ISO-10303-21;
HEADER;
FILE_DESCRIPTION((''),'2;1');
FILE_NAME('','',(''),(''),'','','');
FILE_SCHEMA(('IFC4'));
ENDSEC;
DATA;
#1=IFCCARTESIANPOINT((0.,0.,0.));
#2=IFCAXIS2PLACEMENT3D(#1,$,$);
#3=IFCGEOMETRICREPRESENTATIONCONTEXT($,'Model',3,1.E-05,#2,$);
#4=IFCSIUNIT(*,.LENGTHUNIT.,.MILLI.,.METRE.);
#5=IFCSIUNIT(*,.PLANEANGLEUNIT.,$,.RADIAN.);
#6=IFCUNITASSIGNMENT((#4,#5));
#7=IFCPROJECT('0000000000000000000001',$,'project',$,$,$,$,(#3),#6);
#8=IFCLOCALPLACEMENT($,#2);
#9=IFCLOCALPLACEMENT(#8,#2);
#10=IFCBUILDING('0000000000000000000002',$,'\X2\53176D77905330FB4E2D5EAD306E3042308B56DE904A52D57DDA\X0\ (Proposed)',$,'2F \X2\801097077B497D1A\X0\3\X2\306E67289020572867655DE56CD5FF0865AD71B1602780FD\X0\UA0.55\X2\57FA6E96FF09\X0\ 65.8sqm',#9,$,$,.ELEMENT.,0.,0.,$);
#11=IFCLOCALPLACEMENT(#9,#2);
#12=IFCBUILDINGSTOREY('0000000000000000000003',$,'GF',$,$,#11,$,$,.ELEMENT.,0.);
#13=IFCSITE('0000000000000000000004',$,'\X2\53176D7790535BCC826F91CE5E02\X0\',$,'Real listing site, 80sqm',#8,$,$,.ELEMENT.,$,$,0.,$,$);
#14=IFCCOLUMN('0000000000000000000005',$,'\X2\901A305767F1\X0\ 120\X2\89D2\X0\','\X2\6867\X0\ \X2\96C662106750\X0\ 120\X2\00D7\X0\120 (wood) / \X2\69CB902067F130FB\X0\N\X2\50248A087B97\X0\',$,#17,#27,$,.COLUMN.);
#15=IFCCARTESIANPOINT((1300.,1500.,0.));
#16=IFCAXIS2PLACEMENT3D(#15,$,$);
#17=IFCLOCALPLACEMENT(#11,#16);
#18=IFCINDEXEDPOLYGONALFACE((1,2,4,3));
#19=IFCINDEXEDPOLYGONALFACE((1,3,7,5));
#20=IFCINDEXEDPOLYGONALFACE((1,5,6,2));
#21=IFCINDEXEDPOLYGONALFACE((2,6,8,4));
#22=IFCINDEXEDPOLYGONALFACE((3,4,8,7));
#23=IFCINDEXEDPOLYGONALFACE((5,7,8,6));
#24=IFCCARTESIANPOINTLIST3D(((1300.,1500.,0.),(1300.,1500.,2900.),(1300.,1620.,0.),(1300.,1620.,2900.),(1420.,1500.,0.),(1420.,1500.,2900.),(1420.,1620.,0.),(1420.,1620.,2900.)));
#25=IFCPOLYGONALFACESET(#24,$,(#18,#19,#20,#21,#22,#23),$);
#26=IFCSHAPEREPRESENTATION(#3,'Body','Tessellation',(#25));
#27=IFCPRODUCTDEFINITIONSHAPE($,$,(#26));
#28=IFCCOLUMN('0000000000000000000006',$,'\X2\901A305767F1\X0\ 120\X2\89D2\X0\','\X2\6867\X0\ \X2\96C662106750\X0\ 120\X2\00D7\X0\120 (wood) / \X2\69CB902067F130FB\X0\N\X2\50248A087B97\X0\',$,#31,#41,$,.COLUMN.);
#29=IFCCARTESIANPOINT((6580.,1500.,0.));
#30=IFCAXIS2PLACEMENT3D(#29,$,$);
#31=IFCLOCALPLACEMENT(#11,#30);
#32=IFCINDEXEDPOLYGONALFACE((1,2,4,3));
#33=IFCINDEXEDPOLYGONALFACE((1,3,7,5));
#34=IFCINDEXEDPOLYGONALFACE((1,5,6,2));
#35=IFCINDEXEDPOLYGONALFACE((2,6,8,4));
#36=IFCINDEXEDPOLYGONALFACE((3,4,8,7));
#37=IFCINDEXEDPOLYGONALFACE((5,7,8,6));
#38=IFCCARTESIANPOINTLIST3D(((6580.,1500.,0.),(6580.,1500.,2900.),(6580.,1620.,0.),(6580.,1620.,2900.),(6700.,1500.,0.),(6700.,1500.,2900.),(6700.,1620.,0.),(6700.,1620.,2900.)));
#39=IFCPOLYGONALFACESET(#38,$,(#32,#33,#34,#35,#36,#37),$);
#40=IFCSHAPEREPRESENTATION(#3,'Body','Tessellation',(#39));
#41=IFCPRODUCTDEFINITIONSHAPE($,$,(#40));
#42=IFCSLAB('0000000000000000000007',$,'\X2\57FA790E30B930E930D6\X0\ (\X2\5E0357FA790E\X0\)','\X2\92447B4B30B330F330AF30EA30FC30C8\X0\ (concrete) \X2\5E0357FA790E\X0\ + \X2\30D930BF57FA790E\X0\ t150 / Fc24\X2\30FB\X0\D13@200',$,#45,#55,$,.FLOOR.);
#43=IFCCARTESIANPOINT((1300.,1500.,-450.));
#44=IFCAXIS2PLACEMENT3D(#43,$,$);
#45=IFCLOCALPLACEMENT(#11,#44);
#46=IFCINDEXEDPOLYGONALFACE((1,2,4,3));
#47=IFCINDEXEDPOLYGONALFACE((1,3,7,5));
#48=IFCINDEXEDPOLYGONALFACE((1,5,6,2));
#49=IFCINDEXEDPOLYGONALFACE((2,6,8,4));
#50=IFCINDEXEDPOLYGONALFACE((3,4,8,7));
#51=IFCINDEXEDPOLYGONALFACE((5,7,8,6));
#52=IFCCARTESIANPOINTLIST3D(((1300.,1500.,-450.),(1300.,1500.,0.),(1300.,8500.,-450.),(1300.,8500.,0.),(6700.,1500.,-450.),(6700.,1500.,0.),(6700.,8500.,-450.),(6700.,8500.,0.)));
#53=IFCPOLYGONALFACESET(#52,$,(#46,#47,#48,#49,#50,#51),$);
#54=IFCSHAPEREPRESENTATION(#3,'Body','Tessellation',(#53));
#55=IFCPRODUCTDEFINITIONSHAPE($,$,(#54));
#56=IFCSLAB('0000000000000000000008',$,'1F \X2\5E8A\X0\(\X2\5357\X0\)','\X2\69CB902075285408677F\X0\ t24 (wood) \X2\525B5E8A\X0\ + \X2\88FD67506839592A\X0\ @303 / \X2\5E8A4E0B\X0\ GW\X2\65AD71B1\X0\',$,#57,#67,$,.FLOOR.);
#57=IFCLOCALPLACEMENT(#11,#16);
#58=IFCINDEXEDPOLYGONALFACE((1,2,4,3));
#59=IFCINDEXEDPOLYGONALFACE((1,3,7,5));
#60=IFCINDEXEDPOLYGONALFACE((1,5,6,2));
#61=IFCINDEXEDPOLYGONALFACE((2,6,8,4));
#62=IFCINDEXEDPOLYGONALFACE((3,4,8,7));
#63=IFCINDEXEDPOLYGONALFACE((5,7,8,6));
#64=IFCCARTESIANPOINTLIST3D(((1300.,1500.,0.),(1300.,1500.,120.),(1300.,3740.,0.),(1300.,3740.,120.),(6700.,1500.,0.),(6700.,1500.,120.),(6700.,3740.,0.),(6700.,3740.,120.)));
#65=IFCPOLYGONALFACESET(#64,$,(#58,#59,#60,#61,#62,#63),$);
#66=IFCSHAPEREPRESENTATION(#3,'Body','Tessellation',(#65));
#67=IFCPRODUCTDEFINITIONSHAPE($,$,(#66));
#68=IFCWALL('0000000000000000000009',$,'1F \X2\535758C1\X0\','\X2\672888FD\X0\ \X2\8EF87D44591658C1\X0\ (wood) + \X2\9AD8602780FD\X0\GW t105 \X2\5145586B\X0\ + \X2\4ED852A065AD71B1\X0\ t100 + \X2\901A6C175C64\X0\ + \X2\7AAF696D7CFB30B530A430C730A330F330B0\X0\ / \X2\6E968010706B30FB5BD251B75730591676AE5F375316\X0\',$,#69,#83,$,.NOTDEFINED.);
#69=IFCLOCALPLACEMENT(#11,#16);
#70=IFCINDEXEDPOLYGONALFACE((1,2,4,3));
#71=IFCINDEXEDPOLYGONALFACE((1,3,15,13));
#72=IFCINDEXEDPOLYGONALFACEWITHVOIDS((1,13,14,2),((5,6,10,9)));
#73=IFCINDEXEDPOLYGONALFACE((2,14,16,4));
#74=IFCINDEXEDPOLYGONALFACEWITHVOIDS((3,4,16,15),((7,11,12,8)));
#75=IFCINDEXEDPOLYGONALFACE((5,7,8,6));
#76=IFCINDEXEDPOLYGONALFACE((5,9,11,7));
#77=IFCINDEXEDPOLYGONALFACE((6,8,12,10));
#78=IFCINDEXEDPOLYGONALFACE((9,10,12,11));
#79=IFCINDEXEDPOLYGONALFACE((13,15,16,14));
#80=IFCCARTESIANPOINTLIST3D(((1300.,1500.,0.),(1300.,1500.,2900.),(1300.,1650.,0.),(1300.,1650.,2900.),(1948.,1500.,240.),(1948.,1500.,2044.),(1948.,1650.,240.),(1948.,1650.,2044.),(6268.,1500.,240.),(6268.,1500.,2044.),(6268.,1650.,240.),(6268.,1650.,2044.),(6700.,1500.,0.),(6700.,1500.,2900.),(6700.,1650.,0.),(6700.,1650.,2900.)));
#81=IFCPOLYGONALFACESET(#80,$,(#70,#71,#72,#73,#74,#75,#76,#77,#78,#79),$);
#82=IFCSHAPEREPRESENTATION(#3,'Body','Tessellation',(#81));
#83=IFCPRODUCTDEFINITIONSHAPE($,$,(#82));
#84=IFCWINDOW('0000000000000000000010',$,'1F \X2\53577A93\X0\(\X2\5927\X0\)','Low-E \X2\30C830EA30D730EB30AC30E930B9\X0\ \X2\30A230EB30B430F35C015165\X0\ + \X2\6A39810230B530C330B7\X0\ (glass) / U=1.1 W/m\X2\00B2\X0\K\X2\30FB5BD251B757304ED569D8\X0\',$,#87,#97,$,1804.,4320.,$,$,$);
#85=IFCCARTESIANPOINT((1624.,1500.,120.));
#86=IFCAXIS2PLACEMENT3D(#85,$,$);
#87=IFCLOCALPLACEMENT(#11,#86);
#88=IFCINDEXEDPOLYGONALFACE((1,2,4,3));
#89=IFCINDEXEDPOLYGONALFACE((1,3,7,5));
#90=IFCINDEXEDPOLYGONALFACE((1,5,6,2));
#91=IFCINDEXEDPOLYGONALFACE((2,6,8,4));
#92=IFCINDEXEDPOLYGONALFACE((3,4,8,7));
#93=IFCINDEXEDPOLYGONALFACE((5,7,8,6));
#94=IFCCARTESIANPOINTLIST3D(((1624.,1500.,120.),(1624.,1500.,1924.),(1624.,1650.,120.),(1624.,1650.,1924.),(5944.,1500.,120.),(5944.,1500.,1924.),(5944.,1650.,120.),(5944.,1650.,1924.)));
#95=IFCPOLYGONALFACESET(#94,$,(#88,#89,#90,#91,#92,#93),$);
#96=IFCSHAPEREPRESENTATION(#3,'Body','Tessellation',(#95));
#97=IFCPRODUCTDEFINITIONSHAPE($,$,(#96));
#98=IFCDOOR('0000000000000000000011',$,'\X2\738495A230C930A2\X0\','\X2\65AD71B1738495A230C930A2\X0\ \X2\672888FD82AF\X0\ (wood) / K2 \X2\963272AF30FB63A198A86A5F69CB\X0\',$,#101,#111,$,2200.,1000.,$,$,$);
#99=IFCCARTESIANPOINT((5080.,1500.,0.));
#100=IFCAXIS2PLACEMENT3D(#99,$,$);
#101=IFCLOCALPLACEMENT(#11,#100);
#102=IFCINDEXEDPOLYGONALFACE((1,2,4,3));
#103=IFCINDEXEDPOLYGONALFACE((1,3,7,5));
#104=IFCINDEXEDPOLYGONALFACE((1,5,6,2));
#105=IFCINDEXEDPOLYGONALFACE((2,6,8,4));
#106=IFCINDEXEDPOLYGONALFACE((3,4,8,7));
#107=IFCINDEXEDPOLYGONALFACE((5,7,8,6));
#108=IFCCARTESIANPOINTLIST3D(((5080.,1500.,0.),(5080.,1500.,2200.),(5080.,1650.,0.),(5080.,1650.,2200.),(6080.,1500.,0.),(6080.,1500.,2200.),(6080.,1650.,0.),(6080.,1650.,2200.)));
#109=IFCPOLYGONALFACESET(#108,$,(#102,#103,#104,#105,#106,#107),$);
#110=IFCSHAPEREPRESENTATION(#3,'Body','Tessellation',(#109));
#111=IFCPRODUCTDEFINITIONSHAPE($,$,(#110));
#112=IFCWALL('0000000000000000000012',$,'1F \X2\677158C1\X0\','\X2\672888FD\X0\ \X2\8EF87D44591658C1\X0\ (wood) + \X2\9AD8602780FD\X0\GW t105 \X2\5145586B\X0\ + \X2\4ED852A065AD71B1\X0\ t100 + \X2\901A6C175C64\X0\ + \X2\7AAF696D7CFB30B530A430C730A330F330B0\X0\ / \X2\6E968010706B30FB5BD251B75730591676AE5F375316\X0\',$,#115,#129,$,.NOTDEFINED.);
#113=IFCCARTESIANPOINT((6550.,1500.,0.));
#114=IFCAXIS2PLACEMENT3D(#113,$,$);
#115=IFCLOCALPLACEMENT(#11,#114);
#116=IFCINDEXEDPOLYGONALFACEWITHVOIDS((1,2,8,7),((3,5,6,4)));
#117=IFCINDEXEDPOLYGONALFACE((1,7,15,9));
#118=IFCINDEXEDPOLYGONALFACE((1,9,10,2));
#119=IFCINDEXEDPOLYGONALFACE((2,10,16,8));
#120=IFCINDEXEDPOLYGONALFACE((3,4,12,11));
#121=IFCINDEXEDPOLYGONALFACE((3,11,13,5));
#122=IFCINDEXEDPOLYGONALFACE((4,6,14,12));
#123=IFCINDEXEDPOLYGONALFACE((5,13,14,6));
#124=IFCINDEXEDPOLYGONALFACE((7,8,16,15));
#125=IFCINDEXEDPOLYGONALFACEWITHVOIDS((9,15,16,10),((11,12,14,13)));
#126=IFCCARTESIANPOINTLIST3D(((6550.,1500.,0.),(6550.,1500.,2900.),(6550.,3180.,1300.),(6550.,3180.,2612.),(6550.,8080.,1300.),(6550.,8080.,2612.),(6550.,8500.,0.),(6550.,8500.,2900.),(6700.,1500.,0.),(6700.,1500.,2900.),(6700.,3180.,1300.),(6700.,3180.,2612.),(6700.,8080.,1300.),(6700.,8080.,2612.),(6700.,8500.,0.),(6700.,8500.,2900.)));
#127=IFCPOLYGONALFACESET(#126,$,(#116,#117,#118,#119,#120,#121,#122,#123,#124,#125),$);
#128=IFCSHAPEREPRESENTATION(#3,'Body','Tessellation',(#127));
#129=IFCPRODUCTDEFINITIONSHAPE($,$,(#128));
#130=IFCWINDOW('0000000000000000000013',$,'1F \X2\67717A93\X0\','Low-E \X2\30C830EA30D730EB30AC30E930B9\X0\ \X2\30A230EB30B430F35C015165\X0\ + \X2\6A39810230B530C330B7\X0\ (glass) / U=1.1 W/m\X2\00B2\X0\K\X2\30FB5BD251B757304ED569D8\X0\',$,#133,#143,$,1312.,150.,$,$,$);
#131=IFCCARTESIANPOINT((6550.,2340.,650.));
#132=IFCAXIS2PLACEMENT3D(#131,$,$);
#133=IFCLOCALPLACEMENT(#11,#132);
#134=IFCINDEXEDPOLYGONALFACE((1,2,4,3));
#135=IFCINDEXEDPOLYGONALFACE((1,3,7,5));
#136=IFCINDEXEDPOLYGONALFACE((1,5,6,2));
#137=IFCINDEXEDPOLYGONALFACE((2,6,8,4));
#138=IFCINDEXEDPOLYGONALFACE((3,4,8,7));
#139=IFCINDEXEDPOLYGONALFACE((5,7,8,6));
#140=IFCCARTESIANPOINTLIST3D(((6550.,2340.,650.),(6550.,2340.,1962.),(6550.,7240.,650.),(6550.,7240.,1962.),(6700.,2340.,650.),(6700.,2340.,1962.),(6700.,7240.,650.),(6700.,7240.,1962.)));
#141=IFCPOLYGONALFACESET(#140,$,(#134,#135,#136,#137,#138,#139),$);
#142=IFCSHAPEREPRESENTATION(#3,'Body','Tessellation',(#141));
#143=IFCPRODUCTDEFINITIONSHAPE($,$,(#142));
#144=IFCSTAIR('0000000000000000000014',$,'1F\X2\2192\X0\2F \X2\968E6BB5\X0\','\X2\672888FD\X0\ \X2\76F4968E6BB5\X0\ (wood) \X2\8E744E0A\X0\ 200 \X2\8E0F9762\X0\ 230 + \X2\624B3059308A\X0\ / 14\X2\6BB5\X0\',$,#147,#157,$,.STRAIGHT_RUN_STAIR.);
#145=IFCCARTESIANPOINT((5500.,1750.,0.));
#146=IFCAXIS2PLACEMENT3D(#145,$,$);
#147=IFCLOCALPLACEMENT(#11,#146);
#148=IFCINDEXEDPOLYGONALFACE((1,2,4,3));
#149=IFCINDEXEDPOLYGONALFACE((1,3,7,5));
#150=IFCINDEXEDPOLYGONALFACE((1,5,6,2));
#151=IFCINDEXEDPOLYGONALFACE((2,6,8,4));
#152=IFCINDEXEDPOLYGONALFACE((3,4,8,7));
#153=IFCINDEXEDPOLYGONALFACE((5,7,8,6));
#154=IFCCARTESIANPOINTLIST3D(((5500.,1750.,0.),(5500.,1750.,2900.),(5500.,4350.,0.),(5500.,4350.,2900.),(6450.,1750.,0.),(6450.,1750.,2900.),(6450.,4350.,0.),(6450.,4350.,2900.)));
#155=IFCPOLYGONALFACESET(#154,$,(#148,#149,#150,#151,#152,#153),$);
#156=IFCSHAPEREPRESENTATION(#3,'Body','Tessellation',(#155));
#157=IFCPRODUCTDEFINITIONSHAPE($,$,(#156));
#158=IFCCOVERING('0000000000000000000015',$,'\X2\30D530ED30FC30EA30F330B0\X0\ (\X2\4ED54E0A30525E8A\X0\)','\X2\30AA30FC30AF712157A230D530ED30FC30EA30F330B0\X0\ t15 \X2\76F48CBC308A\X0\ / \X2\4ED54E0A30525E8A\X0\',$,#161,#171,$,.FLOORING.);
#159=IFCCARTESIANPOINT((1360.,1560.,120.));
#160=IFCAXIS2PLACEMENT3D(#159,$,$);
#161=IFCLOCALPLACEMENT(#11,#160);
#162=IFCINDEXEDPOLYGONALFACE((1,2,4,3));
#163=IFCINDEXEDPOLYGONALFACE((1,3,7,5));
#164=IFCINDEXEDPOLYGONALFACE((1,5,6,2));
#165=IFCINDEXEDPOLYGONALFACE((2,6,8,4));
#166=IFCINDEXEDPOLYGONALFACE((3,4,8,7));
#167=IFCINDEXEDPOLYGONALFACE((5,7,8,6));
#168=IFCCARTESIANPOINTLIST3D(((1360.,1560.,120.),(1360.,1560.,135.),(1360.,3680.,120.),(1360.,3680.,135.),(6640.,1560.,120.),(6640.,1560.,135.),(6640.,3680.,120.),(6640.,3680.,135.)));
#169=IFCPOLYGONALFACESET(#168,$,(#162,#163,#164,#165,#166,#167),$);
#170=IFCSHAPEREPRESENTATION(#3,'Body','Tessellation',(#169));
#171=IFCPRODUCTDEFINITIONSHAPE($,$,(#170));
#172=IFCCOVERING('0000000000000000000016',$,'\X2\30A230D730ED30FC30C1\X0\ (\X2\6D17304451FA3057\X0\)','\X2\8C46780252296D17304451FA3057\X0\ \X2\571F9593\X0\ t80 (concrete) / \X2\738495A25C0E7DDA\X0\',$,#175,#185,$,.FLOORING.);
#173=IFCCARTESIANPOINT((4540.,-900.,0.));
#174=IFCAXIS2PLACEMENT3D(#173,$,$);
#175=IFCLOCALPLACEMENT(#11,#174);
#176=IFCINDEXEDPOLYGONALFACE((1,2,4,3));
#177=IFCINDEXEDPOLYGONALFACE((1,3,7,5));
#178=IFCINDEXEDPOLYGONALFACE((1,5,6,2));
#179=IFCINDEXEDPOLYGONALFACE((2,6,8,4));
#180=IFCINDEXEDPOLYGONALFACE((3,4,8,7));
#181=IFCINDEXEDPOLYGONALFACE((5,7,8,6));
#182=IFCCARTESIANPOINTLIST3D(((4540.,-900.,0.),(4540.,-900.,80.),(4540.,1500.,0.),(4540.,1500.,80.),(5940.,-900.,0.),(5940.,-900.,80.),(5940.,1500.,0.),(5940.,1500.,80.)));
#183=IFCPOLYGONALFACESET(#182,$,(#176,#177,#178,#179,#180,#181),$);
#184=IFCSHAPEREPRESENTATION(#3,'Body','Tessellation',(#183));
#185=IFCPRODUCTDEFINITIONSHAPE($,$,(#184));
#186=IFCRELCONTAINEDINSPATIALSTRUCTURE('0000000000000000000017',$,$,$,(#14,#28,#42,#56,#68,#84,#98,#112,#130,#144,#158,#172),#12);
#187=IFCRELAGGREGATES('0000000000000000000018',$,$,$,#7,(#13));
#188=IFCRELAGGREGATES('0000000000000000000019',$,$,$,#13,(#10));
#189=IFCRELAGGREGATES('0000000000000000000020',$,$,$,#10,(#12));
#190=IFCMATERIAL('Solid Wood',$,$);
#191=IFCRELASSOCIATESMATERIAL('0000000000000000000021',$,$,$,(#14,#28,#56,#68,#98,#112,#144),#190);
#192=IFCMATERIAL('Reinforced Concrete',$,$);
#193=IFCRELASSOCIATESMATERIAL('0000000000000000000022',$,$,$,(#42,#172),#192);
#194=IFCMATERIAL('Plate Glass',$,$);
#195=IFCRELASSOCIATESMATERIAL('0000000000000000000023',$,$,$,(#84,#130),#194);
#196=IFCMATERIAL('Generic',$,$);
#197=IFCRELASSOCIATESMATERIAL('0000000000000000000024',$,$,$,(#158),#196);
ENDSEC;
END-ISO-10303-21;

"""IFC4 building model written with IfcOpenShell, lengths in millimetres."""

from ifc_helpers import new_model, si_unit, frame, frame_2d, origin, place, context, project, spatial, rectangle, extrude, material, element, fill, save


model = new_model("IFC4")

# Units and contexts
model_context = context("Model", 3, precision=1e-05, world=origin())
ifc_project = project(units=[si_unit("LENGTHUNIT", "METRE", prefix="MILLI"), si_unit("PLANEANGLEUNIT", "RADIAN")], contexts=[model_context])

# Site, building, storey
site_placement = place(None, origin())
site = spatial("IfcSite", under=ifc_project, at=site_placement, Name="北海道富良野市", ObjectType="Real listing site, 80sqm", CompositionType="ELEMENT", RefElevation=0.0)
building_placement = place(site_placement, origin())
building = spatial("IfcBuilding", under=site, at=building_placement, Name="北海道・中庭のある回遊動線 (Proposed)", ObjectType="2F 耐震等級3の木造在来工法（断熱性能UA0.55基準） 65.8sqm", CompositionType="ELEMENT", ElevationOfRefHeight=0.0, ElevationOfTerrain=0.0)
storey_placement = place(building_placement, origin())
storey = spatial("IfcBuildingStorey", under=building, at=storey_placement, Name="GF", CompositionType="ELEMENT", Elevation=0.0)

# Columns
ifc_material_1 = material(Name="Solid Wood")
column_1_placement = place(storey_placement, frame((1300.0, 1500.0, 0.0)))
element("IfcColumn", 1, at=column_1_placement, inside=storey, material=ifc_material_1, Name="通し柱 120角", Description="桧 集成材 120×120 (wood) / 構造柱・N値計算", PredefinedType="COLUMN", context=model_context, shape_type="SweptSolid", body=[
    extrude(rectangle(XDim=120.0, YDim=120.0, at=frame_2d((60.0, 60.0))), frame((1300.0, 1500.0, 0.0)), (0.0, 0.0, 1.0), 2900.0),
])
column_2_placement = place(storey_placement, frame((6580.0, 1500.0, 0.0)))
element("IfcColumn", 2, at=column_2_placement, inside=storey, material=ifc_material_1, Name="通し柱 120角", Description="桧 集成材 120×120 (wood) / 構造柱・N値計算", PredefinedType="COLUMN", context=model_context, shape_type="SweptSolid", body=[
    extrude(rectangle(XDim=120.0, YDim=120.0, at=frame_2d((60.0, 60.0))), frame((6580.0, 1500.0, 0.0)), (0.0, 0.0, 1.0), 2900.0),
])

# Slabs
ifc_material_2 = material(Name="Reinforced Concrete")
slab_1_placement = place(storey_placement, frame((1300.0, 1500.0, -450.0)))
element("IfcSlab", 3, at=slab_1_placement, inside=storey, material=ifc_material_2, Name="基礎スラブ (布基礎)", Description="鉄筋コンクリート (concrete) 布基礎 + ベタ基礎 t150 / Fc24・D13@200", PredefinedType="FLOOR", context=model_context, shape_type="SweptSolid", body=[
    extrude(rectangle(XDim=5400.0, YDim=7000.0, at=frame_2d((2700.0, 3500.0))), frame((1300.0, 1500.0, -450.0)), (0.0, 0.0, 1.0), 450.0),
])
slab_2_placement = place(storey_placement, frame((1300.0, 1500.0, 0.0)))
element("IfcSlab", 4, at=slab_2_placement, inside=storey, material=ifc_material_1, Name="1F 床(南)", Description="構造用合板 t24 (wood) 剛床 + 製材根太 @303 / 床下 GW断熱", PredefinedType="FLOOR", context=model_context, shape_type="SweptSolid", body=[
    extrude(rectangle(XDim=5400.0, YDim=2240.0, at=frame_2d((2700.0, 1120.0))), frame((1300.0, 1500.0, 0.0)), (0.0, 0.0, 1.0), 120.0),
])

# Wall, openings, window, door
wall_1_placement = place(storey_placement, frame((1300.0, 1500.0, 0.0)))
wall_1 = element("IfcWall", 5, at=wall_1_placement, inside=storey, material=ifc_material_1, Name="1F 南壁", Description="木製 軸組外壁 (wood) + 高性能GW t105 充填 + 付加断熱 t100 + 通気層 + 窯業系サイディング / 準耐火・寒冷地外皮強化", PredefinedType="NOTDEFINED", context=model_context, shape_type="SweptSolid", body=[
    extrude(rectangle(XDim=5400.0, YDim=150.0, at=frame_2d((2700.0, 75.0))), frame((1300.0, 1500.0, 0.0)), (0.0, 0.0, 1.0), 2900.0),
])
opening_1_placement = place(storey_placement, frame((1624.0, 1500.0, 120.0)))
opening_1 = element("IfcOpeningElement", 6, at=opening_1_placement, cuts=wall_1, PredefinedType="NOTDEFINED", context=model_context, shape_type="SweptSolid", body=[
    extrude(rectangle(XDim=4320.0, YDim=150.0, at=frame_2d((2160.0, 75.0))), frame((1624.0, 1500.0, 120.0)), (0.0, 0.0, 1.0), 1804.0),
])
opening_2_placement = place(storey_placement, frame((5080.0, 1500.0, 0.0)))
opening_2 = element("IfcOpeningElement", 7, at=opening_2_placement, cuts=wall_1, PredefinedType="NOTDEFINED", context=model_context, shape_type="SweptSolid", body=[
    extrude(rectangle(XDim=1000.0, YDim=150.0, at=frame_2d((500.0, 75.0))), frame((5080.0, 1500.0, 0.0)), (0.0, 0.0, 1.0), 2200.0),
])
ifc_material_3 = material(Name="Plate Glass")
window_1_placement = place(storey_placement, frame((1624.0, 1500.0, 120.0)))
window_1 = element("IfcWindow", 8, at=window_1_placement, inside=storey, material=ifc_material_3, Name="1F 南窓(大)", Description="Low-E トリプルガラス アルゴン封入 + 樹脂サッシ (glass) / U=1.1 W/m²K・寒冷地仕様", OverallHeight=1804.0, OverallWidth=4320.0, context=model_context, shape_type="SweptSolid", body=[
    extrude(rectangle(XDim=4320.0, YDim=150.0, at=frame_2d((2160.0, 75.0))), frame((1624.0, 1500.0, 120.0)), (0.0, 0.0, 1.0), 1804.0),
])
fill(opening_1, window_1)
door_placement = place(storey_placement, frame((5080.0, 1500.0, 0.0)))
door = element("IfcDoor", 9, at=door_placement, inside=storey, material=ifc_material_1, Name="玄関ドア", Description="断熱玄関ドア 木製芯 (wood) / K2 防犯・採風機構", OverallHeight=2200.0, OverallWidth=1000.0, context=model_context, shape_type="SweptSolid", body=[
    extrude(rectangle(XDim=1000.0, YDim=150.0, at=frame_2d((500.0, 75.0))), frame((5080.0, 1500.0, 0.0)), (0.0, 0.0, 1.0), 2200.0),
])
fill(opening_2, door)

# Wall, opening, window
wall_2_placement = place(storey_placement, frame((6550.0, 1500.0, 0.0)))
wall_2 = element("IfcWall", 10, at=wall_2_placement, inside=storey, material=ifc_material_1, Name="1F 東壁", Description="木製 軸組外壁 (wood) + 高性能GW t105 充填 + 付加断熱 t100 + 通気層 + 窯業系サイディング / 準耐火・寒冷地外皮強化", PredefinedType="NOTDEFINED", context=model_context, shape_type="SweptSolid", body=[
    extrude(rectangle(XDim=150.0, YDim=7000.0, at=frame_2d((75.0, 3500.0))), frame((6550.0, 1500.0, 0.0)), (0.0, 0.0, 1.0), 2900.0),
])
opening_3_placement = place(storey_placement, frame((6550.0, 2340.0, 650.0)))
opening_3 = element("IfcOpeningElement", 11, at=opening_3_placement, cuts=wall_2, PredefinedType="NOTDEFINED", context=model_context, shape_type="SweptSolid", body=[
    extrude(rectangle(XDim=150.0, YDim=4900.0, at=frame_2d((75.0, 2450.0))), frame((6550.0, 2340.0, 650.0)), (0.0, 0.0, 1.0), 1312.0),
])
window_2_placement = place(storey_placement, frame((6550.0, 2340.0, 650.0)))
window_2 = element("IfcWindow", 12, at=window_2_placement, inside=storey, material=ifc_material_3, Name="1F 東窓", Description="Low-E トリプルガラス アルゴン封入 + 樹脂サッシ (glass) / U=1.1 W/m²K・寒冷地仕様", OverallHeight=1312.0, OverallWidth=150.0, context=model_context, shape_type="SweptSolid", body=[
    extrude(rectangle(XDim=150.0, YDim=4900.0, at=frame_2d((75.0, 2450.0))), frame((6550.0, 2340.0, 650.0)), (0.0, 0.0, 1.0), 1312.0),
])
fill(opening_3, window_2)

# Stair
stair_placement = place(storey_placement, frame((5500.0, 1750.0, 0.0)))
element("IfcStair", 13, at=stair_placement, inside=storey, material=ifc_material_1, Name="1F→2F 階段", Description="木製 直階段 (wood) 蹴上 200 踏面 230 + 手すり / 14段", PredefinedType="STRAIGHT_RUN_STAIR", context=model_context, shape_type="SweptSolid", body=[
    extrude(rectangle(XDim=950.0, YDim=2600.0, at=frame_2d((475.0, 1300.0))), frame((5500.0, 1750.0, 0.0)), (0.0, 0.0, 1.0), 2900.0),
])

# Coverings
ifc_material_4 = material(Name="Generic")
covering_1_placement = place(storey_placement, frame((1360.0, 1560.0, 120.0)))
element("IfcCovering", 14, at=covering_1_placement, inside=storey, material=ifc_material_4, Name="フローリング (仕上げ床)", Description="オーク無垢フローリング t15 直貼り / 仕上げ床", PredefinedType="FLOORING", context=model_context, shape_type="SweptSolid", body=[
    extrude(rectangle(XDim=5280.0, YDim=2120.0, at=frame_2d((2640.0, 1060.0))), frame((1360.0, 1560.0, 120.0)), (0.0, 0.0, 1.0), 15.0),
])
covering_2_placement = place(storey_placement, frame((4540.0, -900.0, 0.0)))
element("IfcCovering", 15, at=covering_2_placement, inside=storey, material=ifc_material_2, Name="アプローチ (洗い出し)", Description="豆砂利洗い出し 土間 t80 (concrete) / 玄関導線", PredefinedType="FLOORING", context=model_context, shape_type="SweptSolid", body=[
    extrude(rectangle(XDim=1400.0, YDim=2400.0, at=frame_2d((700.0, 1200.0))), frame((4540.0, -900.0, 0.0)), (0.0, 0.0, 1.0), 80.0),
])

save(model, "model.ifc")
